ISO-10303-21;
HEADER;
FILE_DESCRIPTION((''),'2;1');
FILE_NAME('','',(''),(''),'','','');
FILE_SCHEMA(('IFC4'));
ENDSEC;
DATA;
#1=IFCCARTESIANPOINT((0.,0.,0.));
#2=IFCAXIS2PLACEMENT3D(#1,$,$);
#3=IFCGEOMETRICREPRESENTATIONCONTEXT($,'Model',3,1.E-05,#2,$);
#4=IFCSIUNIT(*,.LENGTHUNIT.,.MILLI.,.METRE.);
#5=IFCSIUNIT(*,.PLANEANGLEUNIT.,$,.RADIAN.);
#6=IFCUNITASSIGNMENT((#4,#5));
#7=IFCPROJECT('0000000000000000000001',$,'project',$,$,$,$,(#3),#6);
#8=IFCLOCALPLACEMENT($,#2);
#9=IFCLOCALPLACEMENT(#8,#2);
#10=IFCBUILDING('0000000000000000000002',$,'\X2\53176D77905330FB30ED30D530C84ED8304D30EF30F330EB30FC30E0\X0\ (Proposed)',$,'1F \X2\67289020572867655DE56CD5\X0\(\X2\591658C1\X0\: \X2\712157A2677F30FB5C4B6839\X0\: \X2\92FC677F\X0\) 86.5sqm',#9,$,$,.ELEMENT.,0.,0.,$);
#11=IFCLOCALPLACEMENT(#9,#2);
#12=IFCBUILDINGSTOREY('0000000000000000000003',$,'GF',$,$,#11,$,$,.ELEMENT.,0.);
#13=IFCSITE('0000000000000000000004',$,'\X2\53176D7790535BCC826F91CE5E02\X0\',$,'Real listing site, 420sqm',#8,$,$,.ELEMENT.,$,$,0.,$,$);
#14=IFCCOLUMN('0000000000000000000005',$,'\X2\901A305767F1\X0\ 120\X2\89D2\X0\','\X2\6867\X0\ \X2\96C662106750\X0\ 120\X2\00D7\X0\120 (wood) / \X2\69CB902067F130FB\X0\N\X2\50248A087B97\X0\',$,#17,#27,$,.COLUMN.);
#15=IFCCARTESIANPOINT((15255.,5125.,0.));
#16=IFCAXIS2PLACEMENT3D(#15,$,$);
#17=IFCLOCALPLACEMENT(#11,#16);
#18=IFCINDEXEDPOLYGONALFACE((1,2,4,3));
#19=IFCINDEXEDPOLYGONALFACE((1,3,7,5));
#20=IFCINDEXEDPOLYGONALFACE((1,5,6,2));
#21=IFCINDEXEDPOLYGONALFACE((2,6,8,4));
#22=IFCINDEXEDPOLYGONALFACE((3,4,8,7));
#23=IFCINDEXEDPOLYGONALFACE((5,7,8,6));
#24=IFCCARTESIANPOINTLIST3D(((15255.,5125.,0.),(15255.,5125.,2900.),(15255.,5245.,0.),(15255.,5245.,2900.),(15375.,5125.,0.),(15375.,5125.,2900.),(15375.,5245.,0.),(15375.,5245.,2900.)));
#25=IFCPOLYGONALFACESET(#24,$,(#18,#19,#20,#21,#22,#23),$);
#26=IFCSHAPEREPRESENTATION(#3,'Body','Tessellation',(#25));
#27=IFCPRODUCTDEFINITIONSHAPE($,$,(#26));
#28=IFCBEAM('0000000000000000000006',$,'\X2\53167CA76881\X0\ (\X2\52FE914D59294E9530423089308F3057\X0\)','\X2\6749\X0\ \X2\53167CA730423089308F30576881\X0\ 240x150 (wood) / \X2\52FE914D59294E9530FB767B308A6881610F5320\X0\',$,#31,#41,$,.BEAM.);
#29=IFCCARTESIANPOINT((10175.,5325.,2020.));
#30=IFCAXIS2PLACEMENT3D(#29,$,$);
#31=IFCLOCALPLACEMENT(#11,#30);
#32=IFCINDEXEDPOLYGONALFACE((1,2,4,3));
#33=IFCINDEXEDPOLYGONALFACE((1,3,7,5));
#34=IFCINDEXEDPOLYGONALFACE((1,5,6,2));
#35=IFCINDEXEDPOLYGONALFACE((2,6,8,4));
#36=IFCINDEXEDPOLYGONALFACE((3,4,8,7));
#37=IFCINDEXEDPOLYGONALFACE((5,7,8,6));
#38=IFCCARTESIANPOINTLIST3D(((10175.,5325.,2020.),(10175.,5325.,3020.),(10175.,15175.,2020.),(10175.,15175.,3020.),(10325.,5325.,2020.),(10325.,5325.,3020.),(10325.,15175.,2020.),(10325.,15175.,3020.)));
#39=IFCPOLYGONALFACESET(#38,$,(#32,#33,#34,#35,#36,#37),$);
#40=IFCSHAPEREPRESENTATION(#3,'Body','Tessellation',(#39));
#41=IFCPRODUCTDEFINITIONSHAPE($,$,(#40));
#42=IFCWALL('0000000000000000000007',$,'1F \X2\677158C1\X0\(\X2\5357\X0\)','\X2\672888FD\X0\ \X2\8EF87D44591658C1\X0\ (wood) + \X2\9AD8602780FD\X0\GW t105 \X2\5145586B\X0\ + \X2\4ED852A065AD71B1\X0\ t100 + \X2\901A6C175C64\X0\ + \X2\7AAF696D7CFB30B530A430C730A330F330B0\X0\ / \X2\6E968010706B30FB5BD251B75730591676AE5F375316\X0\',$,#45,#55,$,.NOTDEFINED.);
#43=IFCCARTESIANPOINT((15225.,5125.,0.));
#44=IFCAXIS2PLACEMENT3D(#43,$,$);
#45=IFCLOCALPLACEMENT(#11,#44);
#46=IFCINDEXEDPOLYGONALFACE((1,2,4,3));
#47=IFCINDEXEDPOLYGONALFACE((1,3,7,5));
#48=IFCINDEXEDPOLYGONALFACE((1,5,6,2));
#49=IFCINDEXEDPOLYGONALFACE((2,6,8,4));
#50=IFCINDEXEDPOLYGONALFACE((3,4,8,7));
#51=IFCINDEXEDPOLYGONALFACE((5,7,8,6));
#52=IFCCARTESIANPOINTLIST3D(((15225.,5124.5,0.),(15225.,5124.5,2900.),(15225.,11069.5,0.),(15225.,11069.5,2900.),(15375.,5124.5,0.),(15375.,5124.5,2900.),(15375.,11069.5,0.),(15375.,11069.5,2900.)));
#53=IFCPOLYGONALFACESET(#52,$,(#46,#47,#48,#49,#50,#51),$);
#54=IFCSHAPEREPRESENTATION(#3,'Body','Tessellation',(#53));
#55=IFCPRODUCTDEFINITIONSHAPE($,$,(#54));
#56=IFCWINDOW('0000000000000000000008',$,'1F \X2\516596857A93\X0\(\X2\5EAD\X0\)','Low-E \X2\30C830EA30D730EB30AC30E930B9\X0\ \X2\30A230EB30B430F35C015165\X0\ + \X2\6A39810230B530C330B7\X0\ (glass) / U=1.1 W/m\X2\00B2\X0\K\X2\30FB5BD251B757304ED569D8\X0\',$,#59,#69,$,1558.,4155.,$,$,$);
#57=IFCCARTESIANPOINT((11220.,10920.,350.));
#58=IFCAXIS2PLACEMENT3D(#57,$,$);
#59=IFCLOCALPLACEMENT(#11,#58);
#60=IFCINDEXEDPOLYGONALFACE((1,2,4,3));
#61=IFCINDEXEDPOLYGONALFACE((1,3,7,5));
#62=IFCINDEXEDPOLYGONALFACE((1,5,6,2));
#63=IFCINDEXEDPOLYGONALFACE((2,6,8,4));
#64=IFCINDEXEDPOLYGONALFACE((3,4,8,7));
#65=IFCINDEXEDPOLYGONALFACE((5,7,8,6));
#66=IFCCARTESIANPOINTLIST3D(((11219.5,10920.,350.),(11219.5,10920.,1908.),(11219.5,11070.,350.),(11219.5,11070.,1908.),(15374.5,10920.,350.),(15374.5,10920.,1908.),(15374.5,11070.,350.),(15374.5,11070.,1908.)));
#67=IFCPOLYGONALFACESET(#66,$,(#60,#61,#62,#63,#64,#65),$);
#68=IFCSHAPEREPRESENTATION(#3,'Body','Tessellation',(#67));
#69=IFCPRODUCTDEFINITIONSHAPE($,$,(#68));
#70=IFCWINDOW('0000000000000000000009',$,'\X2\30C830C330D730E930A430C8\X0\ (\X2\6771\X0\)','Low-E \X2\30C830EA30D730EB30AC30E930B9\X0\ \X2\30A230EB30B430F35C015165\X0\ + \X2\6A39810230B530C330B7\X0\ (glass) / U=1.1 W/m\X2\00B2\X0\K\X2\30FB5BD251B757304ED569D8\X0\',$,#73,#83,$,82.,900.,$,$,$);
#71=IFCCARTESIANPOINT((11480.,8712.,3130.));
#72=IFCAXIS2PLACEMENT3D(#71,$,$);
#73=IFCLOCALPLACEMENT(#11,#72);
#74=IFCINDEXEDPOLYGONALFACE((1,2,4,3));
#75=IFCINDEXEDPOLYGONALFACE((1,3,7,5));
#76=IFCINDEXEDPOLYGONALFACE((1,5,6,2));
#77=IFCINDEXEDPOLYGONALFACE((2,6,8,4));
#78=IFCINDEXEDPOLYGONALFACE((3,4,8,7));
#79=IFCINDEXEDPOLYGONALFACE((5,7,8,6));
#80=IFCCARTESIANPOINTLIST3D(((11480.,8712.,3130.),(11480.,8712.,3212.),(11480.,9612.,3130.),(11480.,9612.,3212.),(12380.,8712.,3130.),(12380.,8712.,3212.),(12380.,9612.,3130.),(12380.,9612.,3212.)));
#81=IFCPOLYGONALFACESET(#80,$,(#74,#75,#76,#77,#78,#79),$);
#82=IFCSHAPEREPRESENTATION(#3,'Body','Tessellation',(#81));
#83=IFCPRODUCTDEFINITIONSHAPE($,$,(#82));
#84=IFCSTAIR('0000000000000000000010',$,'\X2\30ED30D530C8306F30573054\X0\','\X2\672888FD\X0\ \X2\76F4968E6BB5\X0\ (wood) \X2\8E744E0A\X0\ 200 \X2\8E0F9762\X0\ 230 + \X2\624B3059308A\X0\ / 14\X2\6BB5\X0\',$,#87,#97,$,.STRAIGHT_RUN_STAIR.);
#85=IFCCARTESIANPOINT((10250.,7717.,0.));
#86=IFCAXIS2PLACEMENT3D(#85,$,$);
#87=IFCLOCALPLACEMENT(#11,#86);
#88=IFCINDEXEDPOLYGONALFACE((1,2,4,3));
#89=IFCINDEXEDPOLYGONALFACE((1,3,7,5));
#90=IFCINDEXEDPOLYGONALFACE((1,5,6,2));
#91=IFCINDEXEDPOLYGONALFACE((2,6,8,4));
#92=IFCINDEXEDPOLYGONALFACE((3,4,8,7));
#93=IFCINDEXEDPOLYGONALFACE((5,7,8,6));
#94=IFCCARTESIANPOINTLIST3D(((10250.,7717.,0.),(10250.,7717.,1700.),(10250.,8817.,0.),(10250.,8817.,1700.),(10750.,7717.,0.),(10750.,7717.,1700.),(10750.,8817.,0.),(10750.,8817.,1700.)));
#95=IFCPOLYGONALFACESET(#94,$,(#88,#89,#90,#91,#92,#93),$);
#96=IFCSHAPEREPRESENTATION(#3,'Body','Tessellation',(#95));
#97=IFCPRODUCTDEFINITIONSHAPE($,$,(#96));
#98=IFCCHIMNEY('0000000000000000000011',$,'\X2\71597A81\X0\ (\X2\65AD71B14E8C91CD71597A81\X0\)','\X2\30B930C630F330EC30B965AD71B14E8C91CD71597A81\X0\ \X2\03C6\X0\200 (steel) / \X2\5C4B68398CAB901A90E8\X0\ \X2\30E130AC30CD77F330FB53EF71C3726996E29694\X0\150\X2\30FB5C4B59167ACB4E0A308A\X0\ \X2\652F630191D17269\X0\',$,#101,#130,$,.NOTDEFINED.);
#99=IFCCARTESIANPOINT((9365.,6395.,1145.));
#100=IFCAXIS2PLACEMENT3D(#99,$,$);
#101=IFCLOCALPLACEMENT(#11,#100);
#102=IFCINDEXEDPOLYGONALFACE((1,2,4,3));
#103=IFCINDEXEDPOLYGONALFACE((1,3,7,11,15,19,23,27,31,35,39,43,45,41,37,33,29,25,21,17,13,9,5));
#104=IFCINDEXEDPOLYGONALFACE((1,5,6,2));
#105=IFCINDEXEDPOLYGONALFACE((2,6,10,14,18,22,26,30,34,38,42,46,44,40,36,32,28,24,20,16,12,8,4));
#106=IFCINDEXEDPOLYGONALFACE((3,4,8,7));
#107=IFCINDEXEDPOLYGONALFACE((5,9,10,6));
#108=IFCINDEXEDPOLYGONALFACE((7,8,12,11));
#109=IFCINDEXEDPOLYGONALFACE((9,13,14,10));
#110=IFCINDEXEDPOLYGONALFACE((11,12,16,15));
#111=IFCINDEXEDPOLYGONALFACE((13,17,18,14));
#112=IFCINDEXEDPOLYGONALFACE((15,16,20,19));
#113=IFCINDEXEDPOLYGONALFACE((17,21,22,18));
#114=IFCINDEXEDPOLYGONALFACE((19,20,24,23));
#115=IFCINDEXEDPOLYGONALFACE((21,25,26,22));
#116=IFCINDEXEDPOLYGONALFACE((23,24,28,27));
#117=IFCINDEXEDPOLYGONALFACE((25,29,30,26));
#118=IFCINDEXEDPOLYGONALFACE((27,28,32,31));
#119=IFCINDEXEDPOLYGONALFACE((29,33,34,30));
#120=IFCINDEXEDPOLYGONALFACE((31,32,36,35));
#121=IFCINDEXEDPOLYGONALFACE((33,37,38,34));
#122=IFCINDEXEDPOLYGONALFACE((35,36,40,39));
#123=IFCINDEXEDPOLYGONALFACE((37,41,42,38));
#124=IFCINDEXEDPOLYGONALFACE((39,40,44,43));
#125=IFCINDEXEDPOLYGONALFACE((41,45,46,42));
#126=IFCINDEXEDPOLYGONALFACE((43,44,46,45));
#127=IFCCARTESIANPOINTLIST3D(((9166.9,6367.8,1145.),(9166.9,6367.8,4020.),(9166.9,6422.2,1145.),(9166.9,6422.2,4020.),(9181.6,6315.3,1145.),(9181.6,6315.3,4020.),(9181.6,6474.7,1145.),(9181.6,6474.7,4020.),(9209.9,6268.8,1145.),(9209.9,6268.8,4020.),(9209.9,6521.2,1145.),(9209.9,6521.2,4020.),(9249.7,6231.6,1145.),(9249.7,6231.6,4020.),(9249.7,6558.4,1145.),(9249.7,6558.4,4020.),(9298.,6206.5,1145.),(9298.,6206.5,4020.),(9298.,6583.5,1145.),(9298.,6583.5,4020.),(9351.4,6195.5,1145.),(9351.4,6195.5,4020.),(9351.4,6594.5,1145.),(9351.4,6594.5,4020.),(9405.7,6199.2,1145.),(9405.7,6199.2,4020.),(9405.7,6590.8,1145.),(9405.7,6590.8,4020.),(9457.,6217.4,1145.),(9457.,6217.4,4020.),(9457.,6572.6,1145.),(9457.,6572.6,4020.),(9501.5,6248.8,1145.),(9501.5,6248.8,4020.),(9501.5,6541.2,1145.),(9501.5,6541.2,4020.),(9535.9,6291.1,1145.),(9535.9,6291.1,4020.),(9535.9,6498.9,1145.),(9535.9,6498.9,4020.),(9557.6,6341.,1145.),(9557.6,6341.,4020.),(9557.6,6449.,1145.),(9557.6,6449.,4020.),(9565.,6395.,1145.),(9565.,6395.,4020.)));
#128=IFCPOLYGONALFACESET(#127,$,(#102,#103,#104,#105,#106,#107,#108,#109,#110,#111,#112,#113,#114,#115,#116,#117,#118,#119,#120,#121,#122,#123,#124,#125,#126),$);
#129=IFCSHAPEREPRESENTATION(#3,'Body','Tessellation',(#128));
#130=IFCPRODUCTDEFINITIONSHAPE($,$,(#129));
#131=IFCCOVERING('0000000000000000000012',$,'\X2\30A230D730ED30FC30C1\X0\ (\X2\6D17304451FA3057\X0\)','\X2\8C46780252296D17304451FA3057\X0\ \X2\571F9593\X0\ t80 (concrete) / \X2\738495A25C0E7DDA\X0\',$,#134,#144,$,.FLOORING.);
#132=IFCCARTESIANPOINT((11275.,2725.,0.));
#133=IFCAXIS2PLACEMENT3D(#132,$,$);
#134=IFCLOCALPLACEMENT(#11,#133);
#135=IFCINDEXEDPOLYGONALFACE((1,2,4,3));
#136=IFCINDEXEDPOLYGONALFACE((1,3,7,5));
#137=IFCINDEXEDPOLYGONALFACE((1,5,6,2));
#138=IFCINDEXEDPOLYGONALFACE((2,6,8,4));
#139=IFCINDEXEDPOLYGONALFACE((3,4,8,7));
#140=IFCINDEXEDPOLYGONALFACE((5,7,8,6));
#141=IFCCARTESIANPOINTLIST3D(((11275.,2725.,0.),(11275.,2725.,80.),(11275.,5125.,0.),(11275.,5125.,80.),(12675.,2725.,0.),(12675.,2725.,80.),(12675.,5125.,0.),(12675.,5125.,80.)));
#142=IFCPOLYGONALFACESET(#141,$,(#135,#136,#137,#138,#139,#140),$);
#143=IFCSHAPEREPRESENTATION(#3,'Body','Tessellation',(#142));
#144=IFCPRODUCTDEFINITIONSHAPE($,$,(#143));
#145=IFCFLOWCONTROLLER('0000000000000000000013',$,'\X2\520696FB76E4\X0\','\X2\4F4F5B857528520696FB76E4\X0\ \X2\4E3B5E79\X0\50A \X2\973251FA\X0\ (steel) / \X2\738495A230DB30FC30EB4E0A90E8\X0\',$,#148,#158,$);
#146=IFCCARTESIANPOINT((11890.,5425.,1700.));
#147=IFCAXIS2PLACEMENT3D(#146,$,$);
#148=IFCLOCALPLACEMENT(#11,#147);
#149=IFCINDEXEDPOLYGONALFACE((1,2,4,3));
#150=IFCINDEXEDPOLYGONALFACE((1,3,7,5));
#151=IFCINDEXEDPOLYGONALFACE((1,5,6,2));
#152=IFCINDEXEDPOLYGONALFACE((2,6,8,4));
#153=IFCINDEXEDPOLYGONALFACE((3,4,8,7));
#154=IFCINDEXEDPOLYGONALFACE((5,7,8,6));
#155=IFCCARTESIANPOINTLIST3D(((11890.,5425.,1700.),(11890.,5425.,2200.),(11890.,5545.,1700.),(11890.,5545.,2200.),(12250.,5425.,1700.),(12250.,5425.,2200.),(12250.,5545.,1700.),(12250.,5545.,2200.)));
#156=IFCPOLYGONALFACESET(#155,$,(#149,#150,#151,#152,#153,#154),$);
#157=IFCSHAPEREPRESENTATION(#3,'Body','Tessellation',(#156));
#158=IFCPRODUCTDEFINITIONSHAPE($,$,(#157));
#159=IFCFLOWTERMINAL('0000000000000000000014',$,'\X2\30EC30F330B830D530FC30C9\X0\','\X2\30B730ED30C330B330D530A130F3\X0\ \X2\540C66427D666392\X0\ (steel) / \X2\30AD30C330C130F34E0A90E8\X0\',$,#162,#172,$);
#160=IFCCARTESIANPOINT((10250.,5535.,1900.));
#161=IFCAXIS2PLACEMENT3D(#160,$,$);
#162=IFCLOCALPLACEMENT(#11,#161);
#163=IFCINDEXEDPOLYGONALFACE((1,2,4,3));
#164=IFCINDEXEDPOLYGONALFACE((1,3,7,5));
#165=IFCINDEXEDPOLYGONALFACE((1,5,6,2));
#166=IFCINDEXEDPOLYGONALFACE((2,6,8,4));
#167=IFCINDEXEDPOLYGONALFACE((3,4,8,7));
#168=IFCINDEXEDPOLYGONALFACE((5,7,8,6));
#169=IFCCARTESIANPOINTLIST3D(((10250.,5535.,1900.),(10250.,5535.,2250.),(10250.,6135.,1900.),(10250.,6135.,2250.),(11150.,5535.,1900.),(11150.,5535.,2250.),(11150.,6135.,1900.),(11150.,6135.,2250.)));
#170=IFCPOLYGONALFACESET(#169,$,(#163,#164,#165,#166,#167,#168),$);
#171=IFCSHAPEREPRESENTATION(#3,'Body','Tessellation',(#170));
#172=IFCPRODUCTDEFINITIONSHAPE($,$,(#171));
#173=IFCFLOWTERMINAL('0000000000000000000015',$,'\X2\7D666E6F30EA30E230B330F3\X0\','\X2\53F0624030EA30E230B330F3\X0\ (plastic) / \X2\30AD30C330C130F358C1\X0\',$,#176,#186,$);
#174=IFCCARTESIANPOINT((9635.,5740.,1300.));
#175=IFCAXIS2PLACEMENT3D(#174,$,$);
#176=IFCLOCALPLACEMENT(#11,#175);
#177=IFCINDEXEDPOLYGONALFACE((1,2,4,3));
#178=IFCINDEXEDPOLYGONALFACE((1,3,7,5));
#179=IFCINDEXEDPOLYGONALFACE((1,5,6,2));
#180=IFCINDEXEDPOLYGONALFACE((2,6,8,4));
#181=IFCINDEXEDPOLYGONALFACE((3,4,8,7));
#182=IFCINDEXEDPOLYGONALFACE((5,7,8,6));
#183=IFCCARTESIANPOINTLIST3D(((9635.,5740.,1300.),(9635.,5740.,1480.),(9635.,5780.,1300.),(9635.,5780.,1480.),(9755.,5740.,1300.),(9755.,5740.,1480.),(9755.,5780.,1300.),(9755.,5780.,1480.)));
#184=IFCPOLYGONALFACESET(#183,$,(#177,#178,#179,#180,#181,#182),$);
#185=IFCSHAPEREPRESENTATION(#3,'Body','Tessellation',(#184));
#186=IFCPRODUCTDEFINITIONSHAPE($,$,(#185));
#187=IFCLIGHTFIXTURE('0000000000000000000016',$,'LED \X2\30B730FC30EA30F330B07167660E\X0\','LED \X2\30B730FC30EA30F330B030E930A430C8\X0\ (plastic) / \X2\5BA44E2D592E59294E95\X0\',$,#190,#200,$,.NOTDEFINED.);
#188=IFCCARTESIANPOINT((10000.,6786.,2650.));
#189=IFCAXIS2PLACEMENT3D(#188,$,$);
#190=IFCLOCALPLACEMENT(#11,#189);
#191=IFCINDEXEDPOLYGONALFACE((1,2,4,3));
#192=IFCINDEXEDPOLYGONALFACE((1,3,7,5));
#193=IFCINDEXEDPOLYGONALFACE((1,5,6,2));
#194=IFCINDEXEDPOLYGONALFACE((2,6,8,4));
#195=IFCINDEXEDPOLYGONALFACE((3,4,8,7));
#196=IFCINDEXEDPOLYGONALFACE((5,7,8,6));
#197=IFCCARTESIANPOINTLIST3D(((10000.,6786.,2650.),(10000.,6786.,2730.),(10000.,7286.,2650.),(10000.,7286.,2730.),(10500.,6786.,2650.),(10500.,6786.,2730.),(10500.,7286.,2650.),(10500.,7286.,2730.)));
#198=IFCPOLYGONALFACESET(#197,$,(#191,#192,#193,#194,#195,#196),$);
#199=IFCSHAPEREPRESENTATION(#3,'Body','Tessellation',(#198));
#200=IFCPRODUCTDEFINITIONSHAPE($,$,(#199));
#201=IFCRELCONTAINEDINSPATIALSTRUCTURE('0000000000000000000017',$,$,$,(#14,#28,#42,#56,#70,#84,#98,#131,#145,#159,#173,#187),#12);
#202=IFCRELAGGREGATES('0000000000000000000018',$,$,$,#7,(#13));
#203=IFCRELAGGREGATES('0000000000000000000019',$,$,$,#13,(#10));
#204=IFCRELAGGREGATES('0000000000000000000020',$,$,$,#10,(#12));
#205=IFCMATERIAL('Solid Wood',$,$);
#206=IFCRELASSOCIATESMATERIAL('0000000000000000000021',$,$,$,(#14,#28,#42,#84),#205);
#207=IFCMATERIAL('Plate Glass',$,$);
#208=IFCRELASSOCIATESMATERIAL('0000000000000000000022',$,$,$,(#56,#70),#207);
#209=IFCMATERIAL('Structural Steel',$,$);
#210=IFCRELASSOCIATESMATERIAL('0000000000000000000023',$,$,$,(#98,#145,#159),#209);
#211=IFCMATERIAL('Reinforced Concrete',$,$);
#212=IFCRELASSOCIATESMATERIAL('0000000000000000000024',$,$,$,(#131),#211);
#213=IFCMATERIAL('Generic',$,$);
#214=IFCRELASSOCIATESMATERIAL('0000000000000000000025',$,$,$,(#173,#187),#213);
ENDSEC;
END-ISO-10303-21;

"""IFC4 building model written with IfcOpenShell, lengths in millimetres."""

from ifc_helpers import new_model, si_unit, frame, frame_2d, origin, origin_2d, place, context, project, spatial, rectangle, circle, extrude, material, element, fill, save


model = new_model("IFC4")

# Units and contexts
model_context = context("Model", 3, precision=1e-05, world=origin())
ifc_project = project(units=[si_unit("LENGTHUNIT", "METRE", prefix="MILLI"), si_unit("PLANEANGLEUNIT", "RADIAN")], contexts=[model_context])

# Site, building, storey
site_placement = place(None, origin())
site = spatial("IfcSite", under=ifc_project, at=site_placement, Name="北海道富良野市", ObjectType="Real listing site, 420sqm", CompositionType="ELEMENT", RefElevation=0.0)
building_placement = place(site_placement, origin())
building = spatial("IfcBuilding", under=site, at=building_placement, Name="北海道・ロフト付きワンルーム (Proposed)", ObjectType="1F 木造在来工法(外壁: 無垢板・屋根: 鋼板) 86.5sqm", CompositionType="ELEMENT", ElevationOfRefHeight=0.0, ElevationOfTerrain=0.0)
storey_placement = place(building_placement, origin())
storey = spatial("IfcBuildingStorey", under=building, at=storey_placement, Name="GF", CompositionType="ELEMENT", Elevation=0.0)

# Column
ifc_material_1 = material(Name="Solid Wood")
column_1_placement = place(storey_placement, frame((15255.0, 5125.0, 0.0)))
element("IfcColumn", 1, at=column_1_placement, inside=storey, material=ifc_material_1, Name="通し柱 120角", Description="桧 集成材 120×120 (wood) / 構造柱・N値計算", PredefinedType="COLUMN", context=model_context, shape_type="SweptSolid", body=[
    extrude(rectangle(XDim=120.0, YDim=120.0, at=frame_2d((60.0, 60.0))), frame((15255.0, 5125.0, 0.0)), (0.0, 0.0, 1.0), 2900.0),
])

# Beam
beam_1_placement = place(storey_placement, frame((10175.0, 5325.0, 2020.0)))
element("IfcBeam", 2, at=beam_1_placement, inside=storey, material=ifc_material_1, Name="化粧梁 (勾配天井あらわし)", Description="杉 化粧あらわし梁 240x150 (wood) / 勾配天井・登り梁意匠", PredefinedType="BEAM", context=model_context, shape_type="SweptSolid", body=[
    extrude(rectangle(XDim=150.0, YDim=9850.0, at=frame_2d((75.0, 4925.0))), frame((10175.0, 5325.0, 2020.0)), (0.0, 0.0, 1.0), 1000.0),
])

# Wall, opening, window
wall_1_placement = place(storey_placement, frame((15225.0, 5125.0, 0.0)))
wall_1 = element("IfcWall", 3, at=wall_1_placement, inside=storey, material=ifc_material_1, Name="1F 東壁(南)", Description="木製 軸組外壁 (wood) + 高性能GW t105 充填 + 付加断熱 t100 + 通気層 + 窯業系サイディング / 準耐火・寒冷地外皮強化", PredefinedType="NOTDEFINED", context=model_context, shape_type="SweptSolid", body=[
    extrude(rectangle(XDim=150.0, YDim=5945.0, at=frame_2d((75.0, 2972.0))), frame((15225.0, 5125.0, 0.0)), (0.0, 0.0, 1.0), 2900.0),
])
opening_placement = place(storey_placement, frame((11220.0, 10920.0, 350.0)))
opening = element("IfcOpeningElement", 4, at=opening_placement, cuts=wall_1, PredefinedType="NOTDEFINED", context=model_context, shape_type="SweptSolid", body=[
    extrude(rectangle(XDim=4155.0, YDim=150.0, at=frame_2d((2077.0, 75.0))), frame((11220.0, 10920.0, 350.0)), (0.0, 0.0, 1.0), 1558.0),
])
ifc_material_2 = material(Name="Plate Glass")
window_1_placement = place(storey_placement, frame((11220.0, 10920.0, 350.0)))
window_1 = element("IfcWindow", 5, at=window_1_placement, inside=storey, material=ifc_material_2, Name="1F 入隅窓(庭)", Description="Low-E トリプルガラス アルゴン封入 + 樹脂サッシ (glass) / U=1.1 W/m²K・寒冷地仕様", OverallHeight=1558.0, OverallWidth=4155.0, context=model_context, shape_type="SweptSolid", body=[
    extrude(rectangle(XDim=4155.0, YDim=150.0, at=frame_2d((2077.0, 75.0))), frame((11220.0, 10920.0, 350.0)), (0.0, 0.0, 1.0), 1558.0),
])
fill(opening, window_1)

# Window
window_2_placement = place(storey_placement, frame((11480.0, 8712.0, 3130.0)))
element("IfcWindow", 6, at=window_2_placement, inside=storey, material=ifc_material_2, Name="トップライト (東)", Description="Low-E トリプルガラス アルゴン封入 + 樹脂サッシ (glass) / U=1.1 W/m²K・寒冷地仕様", OverallHeight=82.0, OverallWidth=900.0, context=model_context, shape_type="SweptSolid", body=[
    extrude(rectangle(XDim=900.0, YDim=900.0, at=frame_2d((450.0, 450.0))), frame((11480.0, 8712.0, 3130.0)), (0.0, 0.0, 1.0), 82.0),
])

# Stair
stair_placement = place(storey_placement, frame((10250.0, 7717.0, 0.0)))
element("IfcStair", 7, at=stair_placement, inside=storey, material=ifc_material_1, Name="ロフトはしご", Description="木製 直階段 (wood) 蹴上 200 踏面 230 + 手すり / 14段", PredefinedType="STRAIGHT_RUN_STAIR", context=model_context, shape_type="SweptSolid", body=[
    extrude(rectangle(XDim=500.0, YDim=1100.0, at=frame_2d((250.0, 550.0))), frame((10250.0, 7717.0, 0.0)), (0.0, 0.0, 1.0), 1700.0),
])

# Chimney
ifc_material_3 = material(Name="Structural Steel")
chimney_placement = place(storey_placement, frame((9365.0, 6395.0, 1145.0)))
element("IfcChimney", 8, at=chimney_placement, inside=storey, material=ifc_material_3, Name="煙突 (断熱二重煙突)", Description="ステンレス断熱二重煙突 φ200 (steel) / 屋根貫通部 メガネ石・可燃物離隔150・屋外立上り 支持金物", PredefinedType="NOTDEFINED", context=model_context, shape_type="SweptSolid", body=[
    extrude(circle(Radius=200.0, at=origin_2d()), frame((9365.0, 6395.0, 1145.0)), (0.0, 0.0, 1.0), 2875.0),
])

# Covering
ifc_material_4 = material(Name="Reinforced Concrete")
covering_placement = place(storey_placement, frame((11275.0, 2725.0, 0.0)))
element("IfcCovering", 9, at=covering_placement, inside=storey, material=ifc_material_4, Name="アプローチ (洗い出し)", Description="豆砂利洗い出し 土間 t80 (concrete) / 玄関導線", PredefinedType="FLOORING", context=model_context, shape_type="SweptSolid", body=[
    extrude(rectangle(XDim=1400.0, YDim=2400.0, at=frame_2d((700.0, 1200.0))), frame((11275.0, 2725.0, 0.0)), (0.0, 0.0, 1.0), 80.0),
])

# Flow controller
flow_controller_placement = place(storey_placement, frame((11890.0, 5425.0, 1700.0)))
element("IfcFlowController", 10, at=flow_controller_placement, inside=storey, material=ifc_material_3, Name="分電盤", Description="住宅用分電盤 主幹50A 露出 (steel) / 玄関ホール上部", context=model_context, shape_type="SweptSolid", body=[
    extrude(rectangle(XDim=360.0, YDim=120.0, at=frame_2d((180.0, 60.0))), frame((11890.0, 5425.0, 1700.0)), (0.0, 0.0, 1.0), 500.0),
])

# Flow terminals
flow_terminal_1_placement = place(storey_placement, frame((10250.0, 5535.0, 1900.0)))
element("IfcFlowTerminal", 11, at=flow_terminal_1_placement, inside=storey, material=ifc_material_3, Name="レンジフード", Description="シロッコファン 同時給排 (steel) / キッチン上部", context=model_context, shape_type="SweptSolid", body=[
    extrude(rectangle(XDim=900.0, YDim=600.0, at=frame_2d((450.0, 300.0))), frame((10250.0, 5535.0, 1900.0)), (0.0, 0.0, 1.0), 350.0),
])
ifc_material_5 = material(Name="Generic")
flow_terminal_2_placement = place(storey_placement, frame((9635.0, 5740.0, 1300.0)))
element("IfcFlowTerminal", 12, at=flow_terminal_2_placement, inside=storey, material=ifc_material_5, Name="給湯リモコン", Description="台所リモコン (plastic) / キッチン壁", context=model_context, shape_type="SweptSolid", body=[
    extrude(rectangle(XDim=120.0, YDim=40.0, at=frame_2d((60.0, 20.0))), frame((9635.0, 5740.0, 1300.0)), (0.0, 0.0, 1.0), 180.0),
])

# Light fixture
light_fixture_placement = place(storey_placement, frame((10000.0, 6786.0, 2650.0)))
element("IfcLightFixture", 13, at=light_fixture_placement, inside=storey, material=ifc_material_5, Name="LED シーリング照明", Description="LED シーリングライト (plastic) / 室中央天井", PredefinedType="NOTDEFINED", context=model_context, shape_type="SweptSolid", body=[
    extrude(rectangle(XDim=500.0, YDim=500.0, at=frame_2d((250.0, 250.0))), frame((10000.0, 6786.0, 2650.0)), (0.0, 0.0, 1.0), 80.0),
])

save(model, "model.ifc")
